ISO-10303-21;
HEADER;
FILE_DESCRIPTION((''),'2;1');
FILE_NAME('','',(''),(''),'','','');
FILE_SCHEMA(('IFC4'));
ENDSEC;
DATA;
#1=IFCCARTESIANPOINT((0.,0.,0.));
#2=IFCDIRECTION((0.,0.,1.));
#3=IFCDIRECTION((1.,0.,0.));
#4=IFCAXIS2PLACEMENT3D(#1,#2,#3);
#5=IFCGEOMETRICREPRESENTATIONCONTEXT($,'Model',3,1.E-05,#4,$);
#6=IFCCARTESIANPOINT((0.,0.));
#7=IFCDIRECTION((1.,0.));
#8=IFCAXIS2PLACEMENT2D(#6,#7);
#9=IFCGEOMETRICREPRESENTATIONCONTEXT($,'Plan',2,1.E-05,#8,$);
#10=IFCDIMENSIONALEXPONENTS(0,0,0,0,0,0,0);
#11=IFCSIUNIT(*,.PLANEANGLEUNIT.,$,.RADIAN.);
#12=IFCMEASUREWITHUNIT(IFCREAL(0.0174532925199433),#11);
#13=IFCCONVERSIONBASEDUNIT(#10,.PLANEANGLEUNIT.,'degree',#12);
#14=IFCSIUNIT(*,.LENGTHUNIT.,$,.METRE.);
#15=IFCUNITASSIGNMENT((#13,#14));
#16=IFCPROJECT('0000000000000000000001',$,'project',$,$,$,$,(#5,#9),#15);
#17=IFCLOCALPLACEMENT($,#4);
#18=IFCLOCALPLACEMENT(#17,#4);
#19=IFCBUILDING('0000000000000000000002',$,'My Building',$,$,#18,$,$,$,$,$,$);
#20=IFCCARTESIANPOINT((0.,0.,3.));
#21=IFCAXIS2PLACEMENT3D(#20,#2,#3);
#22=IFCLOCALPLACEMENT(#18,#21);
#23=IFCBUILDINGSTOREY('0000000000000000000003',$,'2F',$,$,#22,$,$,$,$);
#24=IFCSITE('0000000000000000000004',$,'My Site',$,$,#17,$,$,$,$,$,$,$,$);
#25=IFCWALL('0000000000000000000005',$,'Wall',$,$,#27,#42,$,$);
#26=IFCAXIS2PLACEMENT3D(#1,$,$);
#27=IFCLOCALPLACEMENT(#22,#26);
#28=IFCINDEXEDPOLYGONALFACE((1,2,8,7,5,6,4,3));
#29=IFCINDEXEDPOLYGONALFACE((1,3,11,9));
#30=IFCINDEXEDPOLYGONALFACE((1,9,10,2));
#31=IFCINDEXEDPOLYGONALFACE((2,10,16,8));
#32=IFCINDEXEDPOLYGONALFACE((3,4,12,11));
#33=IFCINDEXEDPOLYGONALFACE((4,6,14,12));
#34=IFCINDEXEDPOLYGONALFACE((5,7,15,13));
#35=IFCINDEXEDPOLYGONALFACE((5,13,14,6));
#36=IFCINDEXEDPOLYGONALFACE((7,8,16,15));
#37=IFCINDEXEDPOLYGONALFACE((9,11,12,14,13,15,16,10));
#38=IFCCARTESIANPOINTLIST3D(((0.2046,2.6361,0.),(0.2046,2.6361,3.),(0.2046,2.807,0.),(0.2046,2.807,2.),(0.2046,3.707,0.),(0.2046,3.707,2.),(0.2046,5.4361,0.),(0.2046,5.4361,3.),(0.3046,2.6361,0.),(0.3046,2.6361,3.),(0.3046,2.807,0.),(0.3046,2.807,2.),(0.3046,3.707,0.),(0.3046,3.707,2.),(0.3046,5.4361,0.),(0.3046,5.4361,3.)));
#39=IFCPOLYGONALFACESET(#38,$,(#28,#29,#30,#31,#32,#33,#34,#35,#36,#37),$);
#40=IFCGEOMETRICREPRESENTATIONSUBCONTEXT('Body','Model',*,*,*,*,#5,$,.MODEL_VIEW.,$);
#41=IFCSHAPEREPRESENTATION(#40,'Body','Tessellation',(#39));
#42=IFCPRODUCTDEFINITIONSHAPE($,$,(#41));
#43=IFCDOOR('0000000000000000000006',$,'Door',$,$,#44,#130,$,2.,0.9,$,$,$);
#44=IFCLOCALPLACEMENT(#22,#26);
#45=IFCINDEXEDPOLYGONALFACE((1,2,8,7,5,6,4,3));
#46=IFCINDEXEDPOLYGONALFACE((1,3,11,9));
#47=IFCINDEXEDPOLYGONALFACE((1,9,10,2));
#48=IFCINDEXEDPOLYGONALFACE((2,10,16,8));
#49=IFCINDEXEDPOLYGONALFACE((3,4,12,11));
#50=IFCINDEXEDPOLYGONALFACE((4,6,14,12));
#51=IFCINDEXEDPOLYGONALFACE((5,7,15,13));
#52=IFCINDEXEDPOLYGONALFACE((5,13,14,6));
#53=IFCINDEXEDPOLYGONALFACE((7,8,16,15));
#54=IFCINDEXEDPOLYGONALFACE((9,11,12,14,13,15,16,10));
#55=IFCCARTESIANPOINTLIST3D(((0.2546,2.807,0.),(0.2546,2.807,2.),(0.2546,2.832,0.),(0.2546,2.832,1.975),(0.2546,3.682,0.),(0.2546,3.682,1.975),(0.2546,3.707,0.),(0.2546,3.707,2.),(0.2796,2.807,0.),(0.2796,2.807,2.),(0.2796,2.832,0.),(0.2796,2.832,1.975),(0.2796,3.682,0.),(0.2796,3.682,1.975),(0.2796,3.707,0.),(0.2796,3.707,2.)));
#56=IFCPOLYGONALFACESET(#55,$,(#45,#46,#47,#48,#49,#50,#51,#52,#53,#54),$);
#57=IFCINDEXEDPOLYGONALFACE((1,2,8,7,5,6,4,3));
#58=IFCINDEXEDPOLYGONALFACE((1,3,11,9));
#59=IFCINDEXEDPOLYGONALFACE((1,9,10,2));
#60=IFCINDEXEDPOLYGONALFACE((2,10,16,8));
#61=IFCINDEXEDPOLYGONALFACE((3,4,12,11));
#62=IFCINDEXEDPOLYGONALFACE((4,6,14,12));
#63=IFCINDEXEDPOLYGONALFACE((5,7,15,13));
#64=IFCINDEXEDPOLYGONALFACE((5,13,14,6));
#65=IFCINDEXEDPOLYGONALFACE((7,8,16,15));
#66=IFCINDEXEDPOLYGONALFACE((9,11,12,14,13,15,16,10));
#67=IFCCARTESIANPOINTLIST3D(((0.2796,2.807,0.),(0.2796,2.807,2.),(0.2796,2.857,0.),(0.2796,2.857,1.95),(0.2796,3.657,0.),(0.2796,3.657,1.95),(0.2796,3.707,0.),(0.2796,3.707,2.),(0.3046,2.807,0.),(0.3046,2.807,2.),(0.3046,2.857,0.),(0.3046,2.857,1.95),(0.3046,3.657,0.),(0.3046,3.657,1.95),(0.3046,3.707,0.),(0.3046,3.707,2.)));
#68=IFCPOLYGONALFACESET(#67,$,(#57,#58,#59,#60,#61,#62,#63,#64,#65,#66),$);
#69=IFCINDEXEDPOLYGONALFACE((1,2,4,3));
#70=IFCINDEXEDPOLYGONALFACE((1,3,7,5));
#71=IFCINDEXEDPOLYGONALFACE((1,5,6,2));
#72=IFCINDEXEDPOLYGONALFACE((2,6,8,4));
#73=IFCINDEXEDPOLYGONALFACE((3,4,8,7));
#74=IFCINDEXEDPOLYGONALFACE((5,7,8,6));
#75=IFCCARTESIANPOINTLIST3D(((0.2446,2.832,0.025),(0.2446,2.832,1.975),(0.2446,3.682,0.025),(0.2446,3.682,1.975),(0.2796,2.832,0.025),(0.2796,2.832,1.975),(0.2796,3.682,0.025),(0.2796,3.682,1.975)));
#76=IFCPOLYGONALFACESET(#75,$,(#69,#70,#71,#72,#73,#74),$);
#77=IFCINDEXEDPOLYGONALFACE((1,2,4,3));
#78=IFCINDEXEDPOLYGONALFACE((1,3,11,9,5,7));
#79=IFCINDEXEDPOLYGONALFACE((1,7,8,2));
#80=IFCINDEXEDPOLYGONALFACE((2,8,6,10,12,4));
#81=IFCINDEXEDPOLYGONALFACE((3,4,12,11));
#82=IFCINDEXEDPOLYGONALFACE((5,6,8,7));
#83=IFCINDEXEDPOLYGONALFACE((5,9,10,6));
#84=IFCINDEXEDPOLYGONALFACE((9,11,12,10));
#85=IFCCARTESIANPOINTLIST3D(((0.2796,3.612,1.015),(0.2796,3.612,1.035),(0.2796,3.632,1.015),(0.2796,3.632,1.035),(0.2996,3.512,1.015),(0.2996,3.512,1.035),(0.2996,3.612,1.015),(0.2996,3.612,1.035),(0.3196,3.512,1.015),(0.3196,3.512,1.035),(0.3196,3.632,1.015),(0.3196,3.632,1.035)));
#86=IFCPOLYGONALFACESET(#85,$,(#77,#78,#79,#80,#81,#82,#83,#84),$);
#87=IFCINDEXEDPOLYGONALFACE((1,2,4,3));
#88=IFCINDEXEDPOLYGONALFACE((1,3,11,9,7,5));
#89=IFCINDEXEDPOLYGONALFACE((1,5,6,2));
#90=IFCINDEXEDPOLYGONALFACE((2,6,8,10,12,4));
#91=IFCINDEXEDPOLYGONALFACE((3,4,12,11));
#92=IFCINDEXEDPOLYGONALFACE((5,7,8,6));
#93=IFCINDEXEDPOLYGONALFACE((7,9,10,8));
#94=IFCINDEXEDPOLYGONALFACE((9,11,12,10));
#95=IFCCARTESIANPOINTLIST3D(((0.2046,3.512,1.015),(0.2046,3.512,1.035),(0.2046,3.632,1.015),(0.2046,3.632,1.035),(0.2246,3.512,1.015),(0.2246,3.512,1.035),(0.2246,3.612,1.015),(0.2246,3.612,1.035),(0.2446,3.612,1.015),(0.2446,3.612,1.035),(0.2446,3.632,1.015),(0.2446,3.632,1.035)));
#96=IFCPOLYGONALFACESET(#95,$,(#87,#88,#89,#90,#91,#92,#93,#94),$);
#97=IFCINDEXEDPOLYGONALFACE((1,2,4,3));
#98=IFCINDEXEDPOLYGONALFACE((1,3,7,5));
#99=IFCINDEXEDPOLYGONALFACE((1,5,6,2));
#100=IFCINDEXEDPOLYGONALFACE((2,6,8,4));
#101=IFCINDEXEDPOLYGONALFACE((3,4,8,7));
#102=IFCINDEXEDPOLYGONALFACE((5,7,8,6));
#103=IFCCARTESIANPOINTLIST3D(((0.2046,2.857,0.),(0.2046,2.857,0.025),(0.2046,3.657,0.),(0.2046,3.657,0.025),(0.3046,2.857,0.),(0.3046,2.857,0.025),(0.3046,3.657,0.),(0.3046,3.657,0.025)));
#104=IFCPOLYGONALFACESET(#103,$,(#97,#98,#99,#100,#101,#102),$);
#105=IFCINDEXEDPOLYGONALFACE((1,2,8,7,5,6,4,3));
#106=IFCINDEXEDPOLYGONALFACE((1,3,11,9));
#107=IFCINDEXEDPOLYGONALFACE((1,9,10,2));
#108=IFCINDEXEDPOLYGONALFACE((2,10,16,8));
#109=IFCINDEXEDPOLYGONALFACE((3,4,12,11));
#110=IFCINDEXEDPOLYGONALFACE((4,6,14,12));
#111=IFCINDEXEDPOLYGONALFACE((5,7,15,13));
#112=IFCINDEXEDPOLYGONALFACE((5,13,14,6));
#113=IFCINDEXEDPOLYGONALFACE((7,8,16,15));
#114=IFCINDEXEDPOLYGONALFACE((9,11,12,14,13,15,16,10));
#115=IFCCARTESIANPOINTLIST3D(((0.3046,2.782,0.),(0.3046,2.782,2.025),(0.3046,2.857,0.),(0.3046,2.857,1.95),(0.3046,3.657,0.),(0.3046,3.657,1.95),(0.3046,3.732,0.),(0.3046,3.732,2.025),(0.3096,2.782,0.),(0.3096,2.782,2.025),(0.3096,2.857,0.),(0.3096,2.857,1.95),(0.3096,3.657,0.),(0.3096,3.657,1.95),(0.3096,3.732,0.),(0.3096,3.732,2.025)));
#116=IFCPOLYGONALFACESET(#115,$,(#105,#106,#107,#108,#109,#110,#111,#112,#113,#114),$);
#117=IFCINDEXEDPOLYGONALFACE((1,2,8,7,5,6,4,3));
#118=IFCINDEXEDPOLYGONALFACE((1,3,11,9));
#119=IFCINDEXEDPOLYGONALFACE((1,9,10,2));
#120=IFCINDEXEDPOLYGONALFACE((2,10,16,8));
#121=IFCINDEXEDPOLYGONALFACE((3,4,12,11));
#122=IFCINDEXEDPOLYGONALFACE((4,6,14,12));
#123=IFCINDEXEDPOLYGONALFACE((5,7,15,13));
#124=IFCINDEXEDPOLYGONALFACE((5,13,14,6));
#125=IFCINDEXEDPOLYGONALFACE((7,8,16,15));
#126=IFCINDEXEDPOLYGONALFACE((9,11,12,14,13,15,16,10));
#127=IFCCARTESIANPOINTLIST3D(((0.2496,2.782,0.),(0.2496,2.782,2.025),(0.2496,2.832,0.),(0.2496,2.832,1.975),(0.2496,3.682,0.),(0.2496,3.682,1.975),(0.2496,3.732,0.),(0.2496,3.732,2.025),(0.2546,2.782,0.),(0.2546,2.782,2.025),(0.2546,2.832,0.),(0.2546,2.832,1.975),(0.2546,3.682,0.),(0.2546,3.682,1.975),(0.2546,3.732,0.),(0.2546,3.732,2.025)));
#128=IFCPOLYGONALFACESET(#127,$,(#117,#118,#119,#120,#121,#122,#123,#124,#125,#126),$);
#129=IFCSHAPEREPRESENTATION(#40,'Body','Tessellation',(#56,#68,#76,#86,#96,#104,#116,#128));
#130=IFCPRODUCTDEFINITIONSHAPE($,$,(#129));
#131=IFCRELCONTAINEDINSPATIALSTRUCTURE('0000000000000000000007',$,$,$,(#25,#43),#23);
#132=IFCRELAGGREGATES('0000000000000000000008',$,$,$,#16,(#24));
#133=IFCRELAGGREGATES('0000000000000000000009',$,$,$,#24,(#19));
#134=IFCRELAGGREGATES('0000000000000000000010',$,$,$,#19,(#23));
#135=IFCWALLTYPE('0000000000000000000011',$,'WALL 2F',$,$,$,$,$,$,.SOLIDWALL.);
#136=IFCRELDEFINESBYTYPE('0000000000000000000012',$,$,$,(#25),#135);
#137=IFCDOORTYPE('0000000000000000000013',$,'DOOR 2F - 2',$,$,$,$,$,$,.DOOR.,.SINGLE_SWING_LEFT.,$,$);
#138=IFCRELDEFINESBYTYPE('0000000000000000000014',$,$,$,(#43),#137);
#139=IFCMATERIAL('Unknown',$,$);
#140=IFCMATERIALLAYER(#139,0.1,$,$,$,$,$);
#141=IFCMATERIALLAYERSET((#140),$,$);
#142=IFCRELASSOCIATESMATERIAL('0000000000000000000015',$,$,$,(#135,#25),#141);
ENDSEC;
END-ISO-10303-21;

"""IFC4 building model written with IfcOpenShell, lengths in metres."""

from ifc_helpers import new_model, entity, si_unit, converted_unit, frame, origin_with_axes, origin_2d_with_axis, place, context, subcontext, project, spatial, line, indexed_curve, outline, extrude, shape, source, transform, mapped, material, layer, layer_set, layer_usage, type_object, type_shapes, element, fill, save


model = new_model("IFC4")

# Units and contexts
model_context = context("Model", 3, precision=1e-05, world=origin_with_axes())
plan_context = context("Plan", 2, precision=1e-05, world=origin_2d_with_axis())
body_context_1 = subcontext(model_context, "Body", "Model", "MODEL_VIEW")
body_context_2 = subcontext(plan_context, "Body", "Plan", "PLAN_VIEW")
ifc_project = project(units=[converted_unit("PLANEANGLEUNIT", "degree", entity("IfcReal", 0.0174532925199433), si_unit("PLANEANGLEUNIT", "RADIAN"), dimensions=[0, 0, 0, 0, 0, 0, 0]), si_unit("LENGTHUNIT", "METRE")], contexts=[model_context, plan_context])

# Site, building, storey
site_placement = place(None, origin_with_axes())
site = spatial("IfcSite", under=ifc_project, at=site_placement, Name="My Site")
building_placement = place(site_placement, origin_with_axes())
building = spatial("IfcBuilding", under=site, at=building_placement, Name="My Building")
storey_placement = place(building_placement, frame((0.0, 0.0, 3.0), z_axis=(0.0, 0.0, 1.0), x_axis=(1.0, 0.0, 0.0)))
storey = spatial("IfcBuildingStorey", under=building, at=storey_placement, Name="2F")

# Shared definitions
ifc_material = material(Name="Unknown")

# Shared definitions
ifc_layer_1 = layer(ifc_material, 0.1)
ifc_layer_set_1 = layer_set([ifc_layer_1])
wall_type = type_object("IfcWallType", Name="WALL 2F", PredefinedType="SOLIDWALL", material=ifc_layer_set_1)

# Shared definitions
shared_shape_1 = source(origin_with_axes(), body_context_1, "Body", "SweptSolid", [
    extrude(outline(indexed_curve([(0.0, 0.0), (0.9, 0.0), (0.9, 2.0), (0.0, 2.0)], segments=[line(1, 2, 3, 4, 1)])), frame((0.0, -0.6, 0.0), z_axis=(0.0, -1.0, 0.0), x_axis=(1.0, 0.0, 0.0)), (0.0, 0.0, -1.0), 1.2),
])
door_type_1 = type_object("IfcDoorType", Name="DOOR 2F - 2", OperationType="SINGLE_SWING_LEFT", PredefinedType="DOOR")
shared_shape_2 = source(origin_with_axes(), body_context_1, "Body", "SweptSolid", [
    extrude(outline(indexed_curve([(0.0, 0.0), (0.0, 2.0), (0.9, 2.0), (0.9, 0.0), (0.875, 0.0), (0.875, 1.975), (0.025, 1.975), (0.025, 0.0)], segments=[line(1, 2, 3, 4, 5, 6, 7, 8, 1)])), frame((0.0, 0.025, 0.0), z_axis=(0.0, -1.0, 0.0), x_axis=(1.0, 0.0, 0.0)), (0.0, 0.0, -1.0), 0.025),
    extrude(outline(indexed_curve([(0.0, 0.0), (0.0, 2.0), (0.9, 2.0), (0.9, 0.0), (0.85, 0.0), (0.85, 1.95), (0.05, 1.95), (0.05, 0.0)], segments=[line(1, 2, 3, 4, 5, 6, 7, 8, 1)])), frame((0.0, 0.0, 0.0), z_axis=(0.0, -1.0, 0.0), x_axis=(1.0, 0.0, 0.0)), (0.0, 0.0, -1.0), 0.025),
    extrude(outline(indexed_curve([(0.0, 0.0), (0.85, 0.0), (0.85, 0.035), (0.0, 0.035)], segments=[line(1, 2, 3, 4, 1)])), frame((0.025, 0.025, 0.025), z_axis=(0.0, 0.0, 1.0), x_axis=(1.0, 0.0, 0.0)), (0.0, 0.0, 1.0), 1.95),
    extrude(outline(indexed_curve([(0.0, 0.0), (0.0, -0.04), (-0.12, -0.04), (-0.12, -0.02), (-0.02, -0.02), (-0.02, 0.0)], segments=[line(1, 2, 3, 4, 5, 6, 1)])), frame((0.825, 0.025, 1.015), z_axis=(0.0, 0.0, 1.0), x_axis=(1.0, 0.0, 0.0)), (0.0, 0.0, 1.0), 0.02),
    extrude(outline(indexed_curve([(0.0, 0.0), (0.0, 0.04), (-0.12, 0.04), (-0.12, 0.02), (-0.02, 0.02), (-0.02, 0.0)], segments=[line(1, 2, 3, 4, 5, 6, 1)])), frame((0.825, 0.06, 1.015), z_axis=(0.0, 0.0, 1.0), x_axis=(1.0, 0.0, 0.0)), (0.0, 0.0, 1.0), 0.02),
    extrude(outline(indexed_curve([(0.0, 0.0), (0.8, 0.0), (0.8, 0.1), (0.0, 0.1)], segments=[line(1, 2, 3, 4, 1)])), frame((0.05, 0.0, 0.0), z_axis=(0.0, 0.0, 1.0), x_axis=(1.0, 0.0, 0.0)), (0.0, 0.0, 1.0), 0.025),
    extrude(outline(indexed_curve([(0.0, 0.0), (0.0, 2.025), (0.95, 2.025), (0.95, 0.0), (0.875, 0.0), (0.875, 1.95), (0.075, 1.95), (0.075, 0.0)], segments=[line(1, 2, 3, 4, 5, 6, 7, 8, 1)])), frame((-0.025, -0.005, 0.0), z_axis=(0.0, -1.0, 0.0), x_axis=(1.0, 0.0, 0.0)), (0.0, 0.0, -1.0), 0.005),
    extrude(outline(indexed_curve([(0.0, 0.0), (0.0, 2.025), (0.95, 2.025), (0.95, 0.0), (0.9, 0.0), (0.9, 1.975), (0.05, 1.975), (0.05, 0.0)], segments=[line(1, 2, 3, 4, 5, 6, 7, 8, 1)])), frame((-0.025, 0.05, 0.0), z_axis=(0.0, -1.0, 0.0), x_axis=(1.0, 0.0, 0.0)), (0.0, 0.0, -1.0), 0.005),
])
shared_shape_3 = source(origin_with_axes(), body_context_2, "Body", "Curve2D", [
    entity("IfcIndexedPolyCurve", entity("IfcCartesianPointList2D", [[0.0, 0.0], [0.0, 0.05], [0.025, 0.05], [0.025, 0.025], [0.05, 0.025], [0.05, 0.0]]), [entity("IfcLineIndex", [1, 2, 3, 4, 5, 6, 1])]),
    entity("IfcIndexedPolyCurve", entity("IfcCartesianPointList2D", [[0.9, 0.0], [0.9, 0.05], [0.875, 0.05], [0.875, 0.025], [0.85, 0.025], [0.85, 0.0]]), [entity("IfcLineIndex", [1, 2, 3, 4, 5, 6, 1])]),
    entity("IfcTrimmedCurve", entity("IfcEllipse", entity("IfcAxis2Placement2D", entity("IfcCartesianPoint", [0.06, 0.05]), entity("IfcDirection", [1.0, 0.0])), 0.815, 0.85), [entity("IfcCartesianPoint", [0.875, 0.05])], [entity("IfcCartesianPoint", [0.06, 0.9])], True, "CARTESIAN"),
    entity("IfcIndexedPolyCurve", entity("IfcCartesianPointList2D", [[0.025, 0.05], [0.06, 0.05], [0.06, 0.9], [0.025, 0.9]]), [entity("IfcLineIndex", [1, 2, 3, 4, 1])]),
])
type_shapes(door_type_1, [shared_shape_2, shared_shape_3])

# Wall, opening, door
ifc_layer_usage_1 = layer_usage(ifc_layer_set_1, "AXIS2", "POSITIVE", 0.0)
wall_1_placement = place(storey_placement, frame((0.3046, 2.6361, 0.0), z_axis=(0.0, 0.0, 1.0), x_axis=(0.0, 1.0, 0.0)))
wall_1 = element("IfcWall", 1, at=wall_1_placement, inside=storey, type_object=wall_type, material=ifc_layer_usage_1, Name="Wall", context=body_context_1, shape_type="SweptSolid", body=[
    extrude(outline(indexed_curve([(0.0, 0.0), (0.0, 0.1), (2.8, 0.1), (2.8, 0.0)], segments=[line(1, 2, 3, 4, 1)])), origin_with_axes(), (0.0, 0.0, 1.0), 3.0),
])
opening_1_placement = place(wall_1_placement, frame((0.1709, 0.0, 0.0), z_axis=(0.0, 0.0, 1.0), x_axis=(1.0, 0.0, 0.0)))
opening_1 = element("IfcOpeningElement", 2, at=opening_1_placement, cuts=wall_1, PredefinedType="OPENING", context=body_context_1, shape_type="MappedRepresentation", body=[
    mapped(shared_shape_1, transform((0.0, 0.0, 0.0), x_axis=(1.0, 0.0, 0.0), y_axis=(0.0, 1.0, 0.0), z_axis=(0.0, 0.0, 1.0), scale=1.0)),
])
door_1_placement = place(opening_1_placement, origin_with_axes())
door_1 = element("IfcDoor", 3, at=door_1_placement, inside=storey, type_object=door_type_1, Name="Door", OverallHeight=2.0, OverallWidth=0.9, shapes=[
    shape(body_context_1, "Body", "MappedRepresentation", [mapped(shared_shape_2, transform((0.0, 0.0, 0.0), x_axis=(1.0, 0.0, 0.0), y_axis=(0.0, 1.0, 0.0), z_axis=(0.0, 0.0, 1.0), scale=1.0))]),
    shape(body_context_2, "Body", "MappedRepresentation", [mapped(shared_shape_3, transform((0.0, 0.0, 0.0), x_axis=(1.0, 0.0, 0.0), y_axis=(0.0, 1.0, 0.0), z_axis=(0.0, 0.0, 1.0), scale=1.0))]),
])
fill(opening_1, door_1)

save(model, "model.ifc")
